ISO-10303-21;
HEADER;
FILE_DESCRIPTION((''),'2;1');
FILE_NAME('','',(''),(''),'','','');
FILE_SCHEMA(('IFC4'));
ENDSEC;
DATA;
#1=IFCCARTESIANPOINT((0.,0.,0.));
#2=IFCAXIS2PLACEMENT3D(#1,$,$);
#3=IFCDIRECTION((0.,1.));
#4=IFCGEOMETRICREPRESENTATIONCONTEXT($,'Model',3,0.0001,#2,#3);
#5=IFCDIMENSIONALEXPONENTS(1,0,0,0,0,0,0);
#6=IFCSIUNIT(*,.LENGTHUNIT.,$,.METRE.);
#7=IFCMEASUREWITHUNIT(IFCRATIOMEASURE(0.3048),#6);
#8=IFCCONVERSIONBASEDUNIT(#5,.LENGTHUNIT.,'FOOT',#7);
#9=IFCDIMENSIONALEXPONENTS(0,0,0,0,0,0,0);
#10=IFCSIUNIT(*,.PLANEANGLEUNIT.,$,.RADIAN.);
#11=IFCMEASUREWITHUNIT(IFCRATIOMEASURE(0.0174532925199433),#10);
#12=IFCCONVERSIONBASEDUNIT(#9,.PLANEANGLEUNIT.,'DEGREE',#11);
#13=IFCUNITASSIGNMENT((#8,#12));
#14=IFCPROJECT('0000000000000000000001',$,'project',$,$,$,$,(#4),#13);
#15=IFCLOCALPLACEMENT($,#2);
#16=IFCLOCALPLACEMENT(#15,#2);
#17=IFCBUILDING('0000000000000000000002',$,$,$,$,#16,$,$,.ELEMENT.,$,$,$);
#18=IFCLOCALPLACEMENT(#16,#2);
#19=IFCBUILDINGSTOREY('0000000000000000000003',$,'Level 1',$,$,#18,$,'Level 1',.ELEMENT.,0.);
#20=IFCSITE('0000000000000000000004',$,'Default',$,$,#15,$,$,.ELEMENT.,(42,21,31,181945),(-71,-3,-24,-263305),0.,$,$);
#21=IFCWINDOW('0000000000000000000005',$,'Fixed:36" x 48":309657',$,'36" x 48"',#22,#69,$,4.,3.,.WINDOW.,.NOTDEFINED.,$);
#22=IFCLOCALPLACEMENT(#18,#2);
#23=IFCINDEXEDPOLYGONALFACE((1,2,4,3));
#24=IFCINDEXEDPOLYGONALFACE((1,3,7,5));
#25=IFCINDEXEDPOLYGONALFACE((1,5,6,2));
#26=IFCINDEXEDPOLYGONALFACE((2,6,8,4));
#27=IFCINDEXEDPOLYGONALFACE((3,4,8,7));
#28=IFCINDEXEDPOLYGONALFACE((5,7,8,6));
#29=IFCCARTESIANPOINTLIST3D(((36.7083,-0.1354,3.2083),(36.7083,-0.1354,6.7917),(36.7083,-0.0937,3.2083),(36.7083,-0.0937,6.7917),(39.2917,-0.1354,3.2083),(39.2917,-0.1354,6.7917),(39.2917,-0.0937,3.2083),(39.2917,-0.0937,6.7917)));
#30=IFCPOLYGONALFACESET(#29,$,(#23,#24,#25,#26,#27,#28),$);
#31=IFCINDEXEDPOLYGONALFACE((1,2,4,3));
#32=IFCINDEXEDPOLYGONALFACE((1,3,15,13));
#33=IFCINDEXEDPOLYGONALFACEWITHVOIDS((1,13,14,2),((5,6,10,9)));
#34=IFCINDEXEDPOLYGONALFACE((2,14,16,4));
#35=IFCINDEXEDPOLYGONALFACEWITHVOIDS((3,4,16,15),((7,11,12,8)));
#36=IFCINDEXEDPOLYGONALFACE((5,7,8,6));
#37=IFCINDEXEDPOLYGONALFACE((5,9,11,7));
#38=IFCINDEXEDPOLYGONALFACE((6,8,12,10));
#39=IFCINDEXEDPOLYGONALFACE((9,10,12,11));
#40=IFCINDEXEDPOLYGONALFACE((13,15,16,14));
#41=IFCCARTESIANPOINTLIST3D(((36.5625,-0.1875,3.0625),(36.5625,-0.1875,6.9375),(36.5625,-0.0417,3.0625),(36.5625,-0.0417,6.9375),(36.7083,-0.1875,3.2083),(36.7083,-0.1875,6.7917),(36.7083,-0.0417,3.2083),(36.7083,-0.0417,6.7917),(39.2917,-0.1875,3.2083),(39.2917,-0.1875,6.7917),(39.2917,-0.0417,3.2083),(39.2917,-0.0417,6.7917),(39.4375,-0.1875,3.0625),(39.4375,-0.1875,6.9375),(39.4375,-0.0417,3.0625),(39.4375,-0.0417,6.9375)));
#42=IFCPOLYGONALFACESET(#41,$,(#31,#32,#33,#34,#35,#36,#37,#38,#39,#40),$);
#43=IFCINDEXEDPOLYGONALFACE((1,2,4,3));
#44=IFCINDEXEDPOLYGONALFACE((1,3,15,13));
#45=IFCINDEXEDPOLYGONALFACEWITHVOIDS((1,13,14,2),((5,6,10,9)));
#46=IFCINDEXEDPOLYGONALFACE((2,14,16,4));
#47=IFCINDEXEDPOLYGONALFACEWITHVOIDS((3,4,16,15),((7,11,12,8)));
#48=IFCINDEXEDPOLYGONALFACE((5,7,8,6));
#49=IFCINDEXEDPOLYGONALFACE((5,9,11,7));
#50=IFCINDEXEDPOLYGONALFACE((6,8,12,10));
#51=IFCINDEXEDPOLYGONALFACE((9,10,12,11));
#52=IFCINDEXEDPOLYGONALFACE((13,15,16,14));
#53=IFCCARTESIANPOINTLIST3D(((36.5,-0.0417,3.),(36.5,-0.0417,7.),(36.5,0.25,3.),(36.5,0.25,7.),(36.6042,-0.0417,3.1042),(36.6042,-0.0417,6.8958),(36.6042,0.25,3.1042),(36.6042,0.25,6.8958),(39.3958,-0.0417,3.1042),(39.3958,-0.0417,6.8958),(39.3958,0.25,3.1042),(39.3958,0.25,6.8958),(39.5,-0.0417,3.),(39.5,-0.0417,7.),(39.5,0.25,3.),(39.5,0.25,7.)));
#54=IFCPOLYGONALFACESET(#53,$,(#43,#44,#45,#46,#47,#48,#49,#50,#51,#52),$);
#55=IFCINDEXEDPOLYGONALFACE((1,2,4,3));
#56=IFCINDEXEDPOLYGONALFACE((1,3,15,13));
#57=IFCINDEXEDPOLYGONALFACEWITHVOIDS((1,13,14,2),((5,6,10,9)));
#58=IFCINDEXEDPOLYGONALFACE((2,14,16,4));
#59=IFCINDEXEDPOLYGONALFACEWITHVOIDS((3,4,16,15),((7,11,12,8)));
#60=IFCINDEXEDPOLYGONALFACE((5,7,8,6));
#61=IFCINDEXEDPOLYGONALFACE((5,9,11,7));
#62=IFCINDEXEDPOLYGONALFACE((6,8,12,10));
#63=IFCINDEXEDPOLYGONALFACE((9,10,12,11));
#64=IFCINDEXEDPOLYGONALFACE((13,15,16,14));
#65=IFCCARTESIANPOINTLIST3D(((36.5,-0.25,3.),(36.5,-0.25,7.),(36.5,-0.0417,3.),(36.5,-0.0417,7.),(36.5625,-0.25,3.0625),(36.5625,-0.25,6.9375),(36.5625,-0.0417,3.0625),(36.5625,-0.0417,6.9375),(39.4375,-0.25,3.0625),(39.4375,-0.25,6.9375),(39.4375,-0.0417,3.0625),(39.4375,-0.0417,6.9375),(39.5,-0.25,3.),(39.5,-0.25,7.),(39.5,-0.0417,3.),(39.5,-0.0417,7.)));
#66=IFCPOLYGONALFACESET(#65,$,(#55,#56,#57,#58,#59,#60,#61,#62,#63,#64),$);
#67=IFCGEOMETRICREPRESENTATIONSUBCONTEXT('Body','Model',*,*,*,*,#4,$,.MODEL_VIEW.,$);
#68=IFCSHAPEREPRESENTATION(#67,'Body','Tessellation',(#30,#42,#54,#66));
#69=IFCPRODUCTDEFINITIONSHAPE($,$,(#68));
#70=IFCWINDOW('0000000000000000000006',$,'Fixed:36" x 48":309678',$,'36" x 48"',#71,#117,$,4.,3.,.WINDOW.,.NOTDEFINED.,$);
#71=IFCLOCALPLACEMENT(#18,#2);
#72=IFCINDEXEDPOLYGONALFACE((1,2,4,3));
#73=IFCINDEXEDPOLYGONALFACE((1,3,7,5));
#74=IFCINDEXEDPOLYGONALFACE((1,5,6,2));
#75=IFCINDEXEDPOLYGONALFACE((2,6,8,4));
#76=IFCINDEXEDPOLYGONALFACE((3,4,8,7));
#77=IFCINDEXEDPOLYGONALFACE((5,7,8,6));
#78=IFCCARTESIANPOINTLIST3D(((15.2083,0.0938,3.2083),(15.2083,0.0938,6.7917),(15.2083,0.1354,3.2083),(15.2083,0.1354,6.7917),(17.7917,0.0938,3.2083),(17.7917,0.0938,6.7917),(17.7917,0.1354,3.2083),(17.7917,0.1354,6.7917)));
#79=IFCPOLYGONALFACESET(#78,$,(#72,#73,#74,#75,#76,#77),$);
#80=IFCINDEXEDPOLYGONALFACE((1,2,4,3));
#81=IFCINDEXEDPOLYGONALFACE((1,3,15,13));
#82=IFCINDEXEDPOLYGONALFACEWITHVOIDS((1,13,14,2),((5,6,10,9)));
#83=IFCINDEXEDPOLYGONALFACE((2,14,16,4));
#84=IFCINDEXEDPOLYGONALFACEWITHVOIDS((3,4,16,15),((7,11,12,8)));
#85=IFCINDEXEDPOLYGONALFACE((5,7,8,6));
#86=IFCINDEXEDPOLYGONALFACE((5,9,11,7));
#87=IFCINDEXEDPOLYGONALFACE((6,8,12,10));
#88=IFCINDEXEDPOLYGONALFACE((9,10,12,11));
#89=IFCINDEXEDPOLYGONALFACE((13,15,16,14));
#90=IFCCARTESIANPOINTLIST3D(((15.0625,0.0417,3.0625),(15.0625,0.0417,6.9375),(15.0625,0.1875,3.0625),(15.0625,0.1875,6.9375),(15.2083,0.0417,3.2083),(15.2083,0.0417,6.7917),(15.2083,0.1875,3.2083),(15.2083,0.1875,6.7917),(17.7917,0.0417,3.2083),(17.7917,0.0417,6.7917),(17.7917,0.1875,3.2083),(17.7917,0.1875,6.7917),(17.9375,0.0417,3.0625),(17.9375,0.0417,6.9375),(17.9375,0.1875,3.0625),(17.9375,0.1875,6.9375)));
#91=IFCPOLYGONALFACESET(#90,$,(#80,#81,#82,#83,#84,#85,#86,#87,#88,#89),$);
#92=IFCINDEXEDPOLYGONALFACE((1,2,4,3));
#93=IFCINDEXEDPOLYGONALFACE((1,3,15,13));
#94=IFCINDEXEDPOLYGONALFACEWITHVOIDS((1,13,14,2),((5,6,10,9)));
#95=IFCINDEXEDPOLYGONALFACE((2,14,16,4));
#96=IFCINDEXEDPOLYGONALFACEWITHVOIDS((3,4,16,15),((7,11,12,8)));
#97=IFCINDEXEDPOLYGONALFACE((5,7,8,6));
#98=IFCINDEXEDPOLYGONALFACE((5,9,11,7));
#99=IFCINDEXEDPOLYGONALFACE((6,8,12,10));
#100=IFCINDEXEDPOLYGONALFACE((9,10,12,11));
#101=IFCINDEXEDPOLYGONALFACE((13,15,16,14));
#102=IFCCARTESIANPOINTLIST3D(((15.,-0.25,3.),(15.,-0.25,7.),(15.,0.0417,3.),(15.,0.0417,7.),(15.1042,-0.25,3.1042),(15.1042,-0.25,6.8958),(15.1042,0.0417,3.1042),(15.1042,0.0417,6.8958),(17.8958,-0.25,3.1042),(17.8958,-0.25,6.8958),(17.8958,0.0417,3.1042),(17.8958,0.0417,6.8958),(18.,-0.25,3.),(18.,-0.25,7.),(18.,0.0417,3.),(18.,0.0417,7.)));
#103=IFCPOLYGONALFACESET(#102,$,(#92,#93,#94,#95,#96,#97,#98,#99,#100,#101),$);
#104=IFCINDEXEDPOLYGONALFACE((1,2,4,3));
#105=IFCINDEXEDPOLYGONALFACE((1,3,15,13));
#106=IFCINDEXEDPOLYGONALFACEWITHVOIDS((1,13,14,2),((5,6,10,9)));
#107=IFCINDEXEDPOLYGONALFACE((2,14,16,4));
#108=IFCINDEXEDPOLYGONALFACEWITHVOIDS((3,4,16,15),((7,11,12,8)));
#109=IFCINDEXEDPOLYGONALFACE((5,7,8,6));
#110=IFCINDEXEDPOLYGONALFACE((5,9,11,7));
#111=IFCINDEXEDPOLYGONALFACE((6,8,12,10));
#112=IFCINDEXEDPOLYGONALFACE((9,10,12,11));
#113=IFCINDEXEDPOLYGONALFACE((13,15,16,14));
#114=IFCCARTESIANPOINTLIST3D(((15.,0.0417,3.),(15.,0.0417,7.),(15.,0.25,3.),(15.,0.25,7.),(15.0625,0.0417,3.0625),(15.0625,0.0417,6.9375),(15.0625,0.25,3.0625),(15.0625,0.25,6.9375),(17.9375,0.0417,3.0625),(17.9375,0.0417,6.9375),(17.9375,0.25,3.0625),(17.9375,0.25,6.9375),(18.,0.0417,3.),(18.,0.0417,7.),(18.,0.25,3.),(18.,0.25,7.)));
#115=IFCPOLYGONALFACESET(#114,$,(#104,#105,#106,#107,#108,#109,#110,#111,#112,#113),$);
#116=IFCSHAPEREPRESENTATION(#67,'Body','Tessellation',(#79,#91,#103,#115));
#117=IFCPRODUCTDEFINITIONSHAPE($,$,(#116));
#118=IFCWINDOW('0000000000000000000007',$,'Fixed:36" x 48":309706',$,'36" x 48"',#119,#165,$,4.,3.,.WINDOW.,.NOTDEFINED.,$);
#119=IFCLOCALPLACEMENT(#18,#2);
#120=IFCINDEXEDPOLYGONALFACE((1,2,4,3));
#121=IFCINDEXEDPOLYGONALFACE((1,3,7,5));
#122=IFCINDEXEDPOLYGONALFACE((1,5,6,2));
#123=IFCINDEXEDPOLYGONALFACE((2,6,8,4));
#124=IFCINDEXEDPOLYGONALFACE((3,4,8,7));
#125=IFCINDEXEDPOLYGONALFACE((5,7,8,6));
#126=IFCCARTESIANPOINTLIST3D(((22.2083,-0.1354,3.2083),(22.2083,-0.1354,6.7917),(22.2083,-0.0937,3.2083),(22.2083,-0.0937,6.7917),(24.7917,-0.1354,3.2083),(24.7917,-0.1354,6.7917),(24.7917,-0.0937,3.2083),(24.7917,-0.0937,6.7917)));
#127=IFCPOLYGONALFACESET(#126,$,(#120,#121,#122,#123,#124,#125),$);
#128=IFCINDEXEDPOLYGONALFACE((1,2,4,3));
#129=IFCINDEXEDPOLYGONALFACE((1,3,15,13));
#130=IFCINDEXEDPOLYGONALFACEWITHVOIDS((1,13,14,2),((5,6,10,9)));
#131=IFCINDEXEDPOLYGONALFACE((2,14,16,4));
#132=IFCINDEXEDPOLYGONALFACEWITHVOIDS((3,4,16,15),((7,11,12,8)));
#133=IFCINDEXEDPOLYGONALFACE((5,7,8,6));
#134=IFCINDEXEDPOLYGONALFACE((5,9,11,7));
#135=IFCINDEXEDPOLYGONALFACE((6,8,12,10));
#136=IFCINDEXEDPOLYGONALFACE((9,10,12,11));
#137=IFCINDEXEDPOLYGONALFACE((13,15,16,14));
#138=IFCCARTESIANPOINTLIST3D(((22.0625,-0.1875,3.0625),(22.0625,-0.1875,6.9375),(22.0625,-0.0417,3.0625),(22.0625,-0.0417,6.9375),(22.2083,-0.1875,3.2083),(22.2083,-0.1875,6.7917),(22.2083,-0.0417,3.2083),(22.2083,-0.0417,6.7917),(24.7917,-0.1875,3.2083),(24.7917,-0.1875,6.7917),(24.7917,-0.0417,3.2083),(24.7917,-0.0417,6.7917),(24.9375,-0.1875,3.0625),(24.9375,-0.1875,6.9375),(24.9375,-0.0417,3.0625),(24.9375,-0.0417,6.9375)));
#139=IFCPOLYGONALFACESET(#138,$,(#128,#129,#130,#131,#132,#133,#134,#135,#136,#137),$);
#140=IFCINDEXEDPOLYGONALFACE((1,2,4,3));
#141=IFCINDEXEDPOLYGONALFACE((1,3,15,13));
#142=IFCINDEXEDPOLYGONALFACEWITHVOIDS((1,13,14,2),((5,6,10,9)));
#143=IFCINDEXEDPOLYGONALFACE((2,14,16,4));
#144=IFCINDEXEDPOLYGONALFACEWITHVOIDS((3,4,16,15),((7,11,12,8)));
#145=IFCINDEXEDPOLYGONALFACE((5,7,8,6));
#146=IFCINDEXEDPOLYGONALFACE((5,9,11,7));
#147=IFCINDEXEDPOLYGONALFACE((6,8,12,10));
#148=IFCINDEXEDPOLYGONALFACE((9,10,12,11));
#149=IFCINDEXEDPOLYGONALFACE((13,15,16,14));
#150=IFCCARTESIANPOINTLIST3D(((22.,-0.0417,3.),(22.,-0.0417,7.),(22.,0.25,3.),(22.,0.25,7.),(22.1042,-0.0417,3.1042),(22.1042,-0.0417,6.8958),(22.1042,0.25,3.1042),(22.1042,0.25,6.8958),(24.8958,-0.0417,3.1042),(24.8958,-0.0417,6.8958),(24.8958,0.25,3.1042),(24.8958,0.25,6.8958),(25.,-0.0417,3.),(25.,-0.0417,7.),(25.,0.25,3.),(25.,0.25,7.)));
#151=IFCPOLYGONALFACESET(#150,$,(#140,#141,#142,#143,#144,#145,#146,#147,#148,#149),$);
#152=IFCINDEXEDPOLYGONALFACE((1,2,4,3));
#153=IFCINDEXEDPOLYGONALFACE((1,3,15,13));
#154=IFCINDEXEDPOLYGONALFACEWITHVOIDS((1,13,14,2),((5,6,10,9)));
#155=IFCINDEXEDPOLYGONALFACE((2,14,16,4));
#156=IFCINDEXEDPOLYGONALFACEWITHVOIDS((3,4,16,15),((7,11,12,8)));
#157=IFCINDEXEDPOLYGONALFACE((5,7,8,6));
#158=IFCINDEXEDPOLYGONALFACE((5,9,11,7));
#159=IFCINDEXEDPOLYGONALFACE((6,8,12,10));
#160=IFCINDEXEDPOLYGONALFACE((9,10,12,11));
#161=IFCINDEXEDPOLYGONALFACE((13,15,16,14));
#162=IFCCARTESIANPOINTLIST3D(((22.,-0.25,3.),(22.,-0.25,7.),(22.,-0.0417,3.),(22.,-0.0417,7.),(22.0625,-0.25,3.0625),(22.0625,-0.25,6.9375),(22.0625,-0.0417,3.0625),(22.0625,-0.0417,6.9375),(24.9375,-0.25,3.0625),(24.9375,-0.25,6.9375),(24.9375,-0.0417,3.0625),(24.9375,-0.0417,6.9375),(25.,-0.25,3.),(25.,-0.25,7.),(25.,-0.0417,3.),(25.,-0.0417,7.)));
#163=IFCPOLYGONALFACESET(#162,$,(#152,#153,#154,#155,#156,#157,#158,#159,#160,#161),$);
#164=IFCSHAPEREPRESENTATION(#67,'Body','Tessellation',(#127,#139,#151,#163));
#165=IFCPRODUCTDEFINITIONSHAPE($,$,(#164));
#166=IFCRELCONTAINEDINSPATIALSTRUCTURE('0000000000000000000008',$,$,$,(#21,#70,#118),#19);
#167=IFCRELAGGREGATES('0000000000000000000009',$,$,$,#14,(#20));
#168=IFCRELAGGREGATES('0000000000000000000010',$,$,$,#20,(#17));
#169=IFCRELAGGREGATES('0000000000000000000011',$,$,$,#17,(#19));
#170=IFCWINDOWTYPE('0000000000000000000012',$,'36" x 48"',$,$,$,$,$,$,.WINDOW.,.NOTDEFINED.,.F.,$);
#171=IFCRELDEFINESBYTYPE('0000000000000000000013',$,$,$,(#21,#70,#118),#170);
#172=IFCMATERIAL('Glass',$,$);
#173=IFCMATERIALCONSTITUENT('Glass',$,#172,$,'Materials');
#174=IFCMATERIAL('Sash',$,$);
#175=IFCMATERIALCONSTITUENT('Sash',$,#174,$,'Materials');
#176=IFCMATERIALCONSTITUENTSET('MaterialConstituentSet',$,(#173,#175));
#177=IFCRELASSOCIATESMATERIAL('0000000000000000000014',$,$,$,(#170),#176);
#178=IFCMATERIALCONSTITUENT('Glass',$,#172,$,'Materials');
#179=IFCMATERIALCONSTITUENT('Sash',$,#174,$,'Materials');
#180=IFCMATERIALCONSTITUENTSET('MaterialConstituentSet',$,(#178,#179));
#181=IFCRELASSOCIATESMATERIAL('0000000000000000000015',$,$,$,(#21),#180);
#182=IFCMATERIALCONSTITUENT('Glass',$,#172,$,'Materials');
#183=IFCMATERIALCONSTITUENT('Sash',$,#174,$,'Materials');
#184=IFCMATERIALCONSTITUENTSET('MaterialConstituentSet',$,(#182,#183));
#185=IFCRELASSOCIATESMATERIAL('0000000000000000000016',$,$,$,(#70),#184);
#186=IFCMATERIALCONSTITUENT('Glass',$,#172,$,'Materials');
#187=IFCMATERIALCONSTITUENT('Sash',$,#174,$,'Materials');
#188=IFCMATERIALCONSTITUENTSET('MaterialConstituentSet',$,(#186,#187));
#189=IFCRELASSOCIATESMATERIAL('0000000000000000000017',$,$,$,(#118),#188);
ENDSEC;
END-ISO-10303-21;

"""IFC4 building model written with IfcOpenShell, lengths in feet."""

from ifc_helpers import new_model, entity, si_unit, converted_unit, direction, frame, frame_2d, origin, place, context, subcontext, project, spatial, polyline, rectangle, outline, extrude, source, transform, mapped, material, constituent, constituent_set, type_object, type_shapes, element, save


model = new_model("IFC4")

# Units and contexts
model_context = context("Model", 3, precision=0.0001, world=origin(), true_north=direction((0.0, 1.0)))
body_context = subcontext(model_context, "Body", "Model", "MODEL_VIEW")
ifc_project = project(units=[converted_unit("LENGTHUNIT", "FOOT", entity("IfcRatioMeasure", 0.3048), si_unit("LENGTHUNIT", "METRE"), dimensions=[1, 0, 0, 0, 0, 0, 0]), converted_unit("PLANEANGLEUNIT", "DEGREE", entity("IfcRatioMeasure", 0.0174532925199433), si_unit("PLANEANGLEUNIT", "RADIAN"), dimensions=[0, 0, 0, 0, 0, 0, 0])], contexts=[model_context])

# Site, building, storey
site_placement = place(None, origin())
site = spatial("IfcSite", under=ifc_project, at=site_placement, Name="Default", CompositionType="ELEMENT", RefLatitude=(42, 21, 31, 181945), RefLongitude=(-71, -3, -24, -263305), RefElevation=0.0)
building_placement = place(site_placement, origin())
building = spatial("IfcBuilding", under=site, at=building_placement, CompositionType="ELEMENT")
storey_placement = place(building_placement, origin())
storey = spatial("IfcBuildingStorey", under=building, at=storey_placement, Name="Level 1", LongName="Level 1", CompositionType="ELEMENT", Elevation=0.0)

# Shared definitions
placement_1 = place(storey_placement, frame((46.25, 0.0, 0.0), z_axis=(0.0, 0.0, 1.0), x_axis=(-1.0, 0.0, 0.0)))

# Windows
ifc_material_1 = material(Name="Glass")
ifc_material_2 = material(Name="Sash")
ifc_constituent_1 = constituent(ifc_material_1, Name="Glass", Category="Materials")
ifc_constituent_2 = constituent(ifc_material_2, Name="Sash", Category="Materials")
ifc_constituent_set_1 = constituent_set(constituents=[ifc_constituent_1, ifc_constituent_2], Name="MaterialConstituentSet")
window_type = type_object("IfcWindowType", Name="36\" x 48\"", ParameterTakesPrecedence=False, PartitioningType="NOTDEFINED", PredefinedType="WINDOW", material=ifc_constituent_set_1)
shared_shape_1 = source(origin(), body_context, "Body", "SweptSolid", [
    extrude(rectangle(XDim=0.0417, YDim=2.5833, at=frame_2d((0.0, 0.0), x_axis=(1.0, 0.0))), frame((1.5, 0.3646, 0.2083), z_axis=(0.0, 0.0, 1.0), x_axis=(0.0, 1.0, 0.0)), (0.0, 0.0, 1.0), 3.5833),
    extrude(outline(polyline([(-1.4375, -1.9375), (1.4375, -1.9375), (1.4375, 1.9375), (-1.4375, 1.9375), (-1.4375, -1.9375)]), holes=[polyline([(-1.2917, -1.7917), (-1.2917, 1.7917), (1.2917, 1.7917), (1.2917, -1.7917), (-1.2917, -1.7917)])]), frame((1.5, 0.2917, 2.0), z_axis=(0.0, 1.0, 0.0), x_axis=(1.0, 0.0, 0.0)), (0.0, 0.0, 1.0), 0.1458),
    extrude(outline(polyline([(-1.5, -2.0), (1.5, -2.0), (1.5, 2.0), (-1.5, 2.0), (-1.5, -2.0)]), holes=[polyline([(-1.3958, -1.8958), (-1.3958, 1.8958), (1.3958, 1.8958), (1.3958, -1.8958), (-1.3958, -1.8958)])]), frame((1.5, 0.0, 2.0), z_axis=(0.0, 1.0, 0.0), x_axis=(1.0, 0.0, 0.0)), (0.0, 0.0, 1.0), 0.2917),
    extrude(outline(polyline([(-2.0, -1.5), (2.0, -1.5), (2.0, 1.5), (-2.0, 1.5), (-2.0, -1.5)]), holes=[polyline([(-1.9375, -1.4375), (-1.9375, 1.4375), (1.9375, 1.4375), (1.9375, -1.4375), (-1.9375, -1.4375)])]), frame((1.5, 0.2917, 2.0), z_axis=(0.0, 1.0, 0.0), x_axis=(0.0, 0.0, -1.0)), (0.0, 0.0, 1.0), 0.2083),
])
type_shapes(window_type, [shared_shape_1])
ifc_constituent_3 = constituent(ifc_material_1, Name="Glass", Category="Materials")
ifc_constituent_4 = constituent(ifc_material_2, Name="Sash", Category="Materials")
ifc_constituent_set_2 = constituent_set(constituents=[ifc_constituent_3, ifc_constituent_4], Name="MaterialConstituentSet")
placement_2 = place(placement_1, frame((6.75, -0.25, 3.0)))
window_1_placement = place(placement_2, origin())
element("IfcWindow", 1, at=window_1_placement, inside=storey, type_object=window_type, material=ifc_constituent_set_2, Name="Fixed:36\" x 48\":309657", ObjectType="36\" x 48\"", OverallHeight=4.0, OverallWidth=3.0, PartitioningType="NOTDEFINED", PredefinedType="WINDOW", context=body_context, shape_type="MappedRepresentation", body=[
    mapped(shared_shape_1, transform((0.0, 0.0, 0.0), scale=1.0)),
])
ifc_constituent_5 = constituent(ifc_material_1, Name="Glass", Category="Materials")
ifc_constituent_6 = constituent(ifc_material_2, Name="Sash", Category="Materials")
ifc_constituent_set_3 = constituent_set(constituents=[ifc_constituent_5, ifc_constituent_6], Name="MaterialConstituentSet")
placement_3 = place(placement_1, frame((31.25, 0.25, 3.0)))
window_2_placement = place(placement_3, frame((0.0, 0.0, 0.0), z_axis=(0.0, 0.0, 1.0), x_axis=(-1.0, 0.0, 0.0)))
element("IfcWindow", 2, at=window_2_placement, inside=storey, type_object=window_type, material=ifc_constituent_set_3, Name="Fixed:36\" x 48\":309678", ObjectType="36\" x 48\"", OverallHeight=4.0, OverallWidth=3.0, PartitioningType="NOTDEFINED", PredefinedType="WINDOW", context=body_context, shape_type="MappedRepresentation", body=[
    mapped(shared_shape_1, transform((0.0, 0.0, 0.0), scale=1.0)),
])
ifc_constituent_7 = constituent(ifc_material_1, Name="Glass", Category="Materials")
ifc_constituent_8 = constituent(ifc_material_2, Name="Sash", Category="Materials")
ifc_constituent_set_4 = constituent_set(constituents=[ifc_constituent_7, ifc_constituent_8], Name="MaterialConstituentSet")
placement_4 = place(placement_1, frame((21.25, -0.25, 3.0)))
window_3_placement = place(placement_4, origin())
element("IfcWindow", 3, at=window_3_placement, inside=storey, type_object=window_type, material=ifc_constituent_set_4, Name="Fixed:36\" x 48\":309706", ObjectType="36\" x 48\"", OverallHeight=4.0, OverallWidth=3.0, PartitioningType="NOTDEFINED", PredefinedType="WINDOW", context=body_context, shape_type="MappedRepresentation", body=[
    mapped(shared_shape_1, transform((0.0, 0.0, 0.0), scale=1.0)),
])

save(model, "model.ifc")
